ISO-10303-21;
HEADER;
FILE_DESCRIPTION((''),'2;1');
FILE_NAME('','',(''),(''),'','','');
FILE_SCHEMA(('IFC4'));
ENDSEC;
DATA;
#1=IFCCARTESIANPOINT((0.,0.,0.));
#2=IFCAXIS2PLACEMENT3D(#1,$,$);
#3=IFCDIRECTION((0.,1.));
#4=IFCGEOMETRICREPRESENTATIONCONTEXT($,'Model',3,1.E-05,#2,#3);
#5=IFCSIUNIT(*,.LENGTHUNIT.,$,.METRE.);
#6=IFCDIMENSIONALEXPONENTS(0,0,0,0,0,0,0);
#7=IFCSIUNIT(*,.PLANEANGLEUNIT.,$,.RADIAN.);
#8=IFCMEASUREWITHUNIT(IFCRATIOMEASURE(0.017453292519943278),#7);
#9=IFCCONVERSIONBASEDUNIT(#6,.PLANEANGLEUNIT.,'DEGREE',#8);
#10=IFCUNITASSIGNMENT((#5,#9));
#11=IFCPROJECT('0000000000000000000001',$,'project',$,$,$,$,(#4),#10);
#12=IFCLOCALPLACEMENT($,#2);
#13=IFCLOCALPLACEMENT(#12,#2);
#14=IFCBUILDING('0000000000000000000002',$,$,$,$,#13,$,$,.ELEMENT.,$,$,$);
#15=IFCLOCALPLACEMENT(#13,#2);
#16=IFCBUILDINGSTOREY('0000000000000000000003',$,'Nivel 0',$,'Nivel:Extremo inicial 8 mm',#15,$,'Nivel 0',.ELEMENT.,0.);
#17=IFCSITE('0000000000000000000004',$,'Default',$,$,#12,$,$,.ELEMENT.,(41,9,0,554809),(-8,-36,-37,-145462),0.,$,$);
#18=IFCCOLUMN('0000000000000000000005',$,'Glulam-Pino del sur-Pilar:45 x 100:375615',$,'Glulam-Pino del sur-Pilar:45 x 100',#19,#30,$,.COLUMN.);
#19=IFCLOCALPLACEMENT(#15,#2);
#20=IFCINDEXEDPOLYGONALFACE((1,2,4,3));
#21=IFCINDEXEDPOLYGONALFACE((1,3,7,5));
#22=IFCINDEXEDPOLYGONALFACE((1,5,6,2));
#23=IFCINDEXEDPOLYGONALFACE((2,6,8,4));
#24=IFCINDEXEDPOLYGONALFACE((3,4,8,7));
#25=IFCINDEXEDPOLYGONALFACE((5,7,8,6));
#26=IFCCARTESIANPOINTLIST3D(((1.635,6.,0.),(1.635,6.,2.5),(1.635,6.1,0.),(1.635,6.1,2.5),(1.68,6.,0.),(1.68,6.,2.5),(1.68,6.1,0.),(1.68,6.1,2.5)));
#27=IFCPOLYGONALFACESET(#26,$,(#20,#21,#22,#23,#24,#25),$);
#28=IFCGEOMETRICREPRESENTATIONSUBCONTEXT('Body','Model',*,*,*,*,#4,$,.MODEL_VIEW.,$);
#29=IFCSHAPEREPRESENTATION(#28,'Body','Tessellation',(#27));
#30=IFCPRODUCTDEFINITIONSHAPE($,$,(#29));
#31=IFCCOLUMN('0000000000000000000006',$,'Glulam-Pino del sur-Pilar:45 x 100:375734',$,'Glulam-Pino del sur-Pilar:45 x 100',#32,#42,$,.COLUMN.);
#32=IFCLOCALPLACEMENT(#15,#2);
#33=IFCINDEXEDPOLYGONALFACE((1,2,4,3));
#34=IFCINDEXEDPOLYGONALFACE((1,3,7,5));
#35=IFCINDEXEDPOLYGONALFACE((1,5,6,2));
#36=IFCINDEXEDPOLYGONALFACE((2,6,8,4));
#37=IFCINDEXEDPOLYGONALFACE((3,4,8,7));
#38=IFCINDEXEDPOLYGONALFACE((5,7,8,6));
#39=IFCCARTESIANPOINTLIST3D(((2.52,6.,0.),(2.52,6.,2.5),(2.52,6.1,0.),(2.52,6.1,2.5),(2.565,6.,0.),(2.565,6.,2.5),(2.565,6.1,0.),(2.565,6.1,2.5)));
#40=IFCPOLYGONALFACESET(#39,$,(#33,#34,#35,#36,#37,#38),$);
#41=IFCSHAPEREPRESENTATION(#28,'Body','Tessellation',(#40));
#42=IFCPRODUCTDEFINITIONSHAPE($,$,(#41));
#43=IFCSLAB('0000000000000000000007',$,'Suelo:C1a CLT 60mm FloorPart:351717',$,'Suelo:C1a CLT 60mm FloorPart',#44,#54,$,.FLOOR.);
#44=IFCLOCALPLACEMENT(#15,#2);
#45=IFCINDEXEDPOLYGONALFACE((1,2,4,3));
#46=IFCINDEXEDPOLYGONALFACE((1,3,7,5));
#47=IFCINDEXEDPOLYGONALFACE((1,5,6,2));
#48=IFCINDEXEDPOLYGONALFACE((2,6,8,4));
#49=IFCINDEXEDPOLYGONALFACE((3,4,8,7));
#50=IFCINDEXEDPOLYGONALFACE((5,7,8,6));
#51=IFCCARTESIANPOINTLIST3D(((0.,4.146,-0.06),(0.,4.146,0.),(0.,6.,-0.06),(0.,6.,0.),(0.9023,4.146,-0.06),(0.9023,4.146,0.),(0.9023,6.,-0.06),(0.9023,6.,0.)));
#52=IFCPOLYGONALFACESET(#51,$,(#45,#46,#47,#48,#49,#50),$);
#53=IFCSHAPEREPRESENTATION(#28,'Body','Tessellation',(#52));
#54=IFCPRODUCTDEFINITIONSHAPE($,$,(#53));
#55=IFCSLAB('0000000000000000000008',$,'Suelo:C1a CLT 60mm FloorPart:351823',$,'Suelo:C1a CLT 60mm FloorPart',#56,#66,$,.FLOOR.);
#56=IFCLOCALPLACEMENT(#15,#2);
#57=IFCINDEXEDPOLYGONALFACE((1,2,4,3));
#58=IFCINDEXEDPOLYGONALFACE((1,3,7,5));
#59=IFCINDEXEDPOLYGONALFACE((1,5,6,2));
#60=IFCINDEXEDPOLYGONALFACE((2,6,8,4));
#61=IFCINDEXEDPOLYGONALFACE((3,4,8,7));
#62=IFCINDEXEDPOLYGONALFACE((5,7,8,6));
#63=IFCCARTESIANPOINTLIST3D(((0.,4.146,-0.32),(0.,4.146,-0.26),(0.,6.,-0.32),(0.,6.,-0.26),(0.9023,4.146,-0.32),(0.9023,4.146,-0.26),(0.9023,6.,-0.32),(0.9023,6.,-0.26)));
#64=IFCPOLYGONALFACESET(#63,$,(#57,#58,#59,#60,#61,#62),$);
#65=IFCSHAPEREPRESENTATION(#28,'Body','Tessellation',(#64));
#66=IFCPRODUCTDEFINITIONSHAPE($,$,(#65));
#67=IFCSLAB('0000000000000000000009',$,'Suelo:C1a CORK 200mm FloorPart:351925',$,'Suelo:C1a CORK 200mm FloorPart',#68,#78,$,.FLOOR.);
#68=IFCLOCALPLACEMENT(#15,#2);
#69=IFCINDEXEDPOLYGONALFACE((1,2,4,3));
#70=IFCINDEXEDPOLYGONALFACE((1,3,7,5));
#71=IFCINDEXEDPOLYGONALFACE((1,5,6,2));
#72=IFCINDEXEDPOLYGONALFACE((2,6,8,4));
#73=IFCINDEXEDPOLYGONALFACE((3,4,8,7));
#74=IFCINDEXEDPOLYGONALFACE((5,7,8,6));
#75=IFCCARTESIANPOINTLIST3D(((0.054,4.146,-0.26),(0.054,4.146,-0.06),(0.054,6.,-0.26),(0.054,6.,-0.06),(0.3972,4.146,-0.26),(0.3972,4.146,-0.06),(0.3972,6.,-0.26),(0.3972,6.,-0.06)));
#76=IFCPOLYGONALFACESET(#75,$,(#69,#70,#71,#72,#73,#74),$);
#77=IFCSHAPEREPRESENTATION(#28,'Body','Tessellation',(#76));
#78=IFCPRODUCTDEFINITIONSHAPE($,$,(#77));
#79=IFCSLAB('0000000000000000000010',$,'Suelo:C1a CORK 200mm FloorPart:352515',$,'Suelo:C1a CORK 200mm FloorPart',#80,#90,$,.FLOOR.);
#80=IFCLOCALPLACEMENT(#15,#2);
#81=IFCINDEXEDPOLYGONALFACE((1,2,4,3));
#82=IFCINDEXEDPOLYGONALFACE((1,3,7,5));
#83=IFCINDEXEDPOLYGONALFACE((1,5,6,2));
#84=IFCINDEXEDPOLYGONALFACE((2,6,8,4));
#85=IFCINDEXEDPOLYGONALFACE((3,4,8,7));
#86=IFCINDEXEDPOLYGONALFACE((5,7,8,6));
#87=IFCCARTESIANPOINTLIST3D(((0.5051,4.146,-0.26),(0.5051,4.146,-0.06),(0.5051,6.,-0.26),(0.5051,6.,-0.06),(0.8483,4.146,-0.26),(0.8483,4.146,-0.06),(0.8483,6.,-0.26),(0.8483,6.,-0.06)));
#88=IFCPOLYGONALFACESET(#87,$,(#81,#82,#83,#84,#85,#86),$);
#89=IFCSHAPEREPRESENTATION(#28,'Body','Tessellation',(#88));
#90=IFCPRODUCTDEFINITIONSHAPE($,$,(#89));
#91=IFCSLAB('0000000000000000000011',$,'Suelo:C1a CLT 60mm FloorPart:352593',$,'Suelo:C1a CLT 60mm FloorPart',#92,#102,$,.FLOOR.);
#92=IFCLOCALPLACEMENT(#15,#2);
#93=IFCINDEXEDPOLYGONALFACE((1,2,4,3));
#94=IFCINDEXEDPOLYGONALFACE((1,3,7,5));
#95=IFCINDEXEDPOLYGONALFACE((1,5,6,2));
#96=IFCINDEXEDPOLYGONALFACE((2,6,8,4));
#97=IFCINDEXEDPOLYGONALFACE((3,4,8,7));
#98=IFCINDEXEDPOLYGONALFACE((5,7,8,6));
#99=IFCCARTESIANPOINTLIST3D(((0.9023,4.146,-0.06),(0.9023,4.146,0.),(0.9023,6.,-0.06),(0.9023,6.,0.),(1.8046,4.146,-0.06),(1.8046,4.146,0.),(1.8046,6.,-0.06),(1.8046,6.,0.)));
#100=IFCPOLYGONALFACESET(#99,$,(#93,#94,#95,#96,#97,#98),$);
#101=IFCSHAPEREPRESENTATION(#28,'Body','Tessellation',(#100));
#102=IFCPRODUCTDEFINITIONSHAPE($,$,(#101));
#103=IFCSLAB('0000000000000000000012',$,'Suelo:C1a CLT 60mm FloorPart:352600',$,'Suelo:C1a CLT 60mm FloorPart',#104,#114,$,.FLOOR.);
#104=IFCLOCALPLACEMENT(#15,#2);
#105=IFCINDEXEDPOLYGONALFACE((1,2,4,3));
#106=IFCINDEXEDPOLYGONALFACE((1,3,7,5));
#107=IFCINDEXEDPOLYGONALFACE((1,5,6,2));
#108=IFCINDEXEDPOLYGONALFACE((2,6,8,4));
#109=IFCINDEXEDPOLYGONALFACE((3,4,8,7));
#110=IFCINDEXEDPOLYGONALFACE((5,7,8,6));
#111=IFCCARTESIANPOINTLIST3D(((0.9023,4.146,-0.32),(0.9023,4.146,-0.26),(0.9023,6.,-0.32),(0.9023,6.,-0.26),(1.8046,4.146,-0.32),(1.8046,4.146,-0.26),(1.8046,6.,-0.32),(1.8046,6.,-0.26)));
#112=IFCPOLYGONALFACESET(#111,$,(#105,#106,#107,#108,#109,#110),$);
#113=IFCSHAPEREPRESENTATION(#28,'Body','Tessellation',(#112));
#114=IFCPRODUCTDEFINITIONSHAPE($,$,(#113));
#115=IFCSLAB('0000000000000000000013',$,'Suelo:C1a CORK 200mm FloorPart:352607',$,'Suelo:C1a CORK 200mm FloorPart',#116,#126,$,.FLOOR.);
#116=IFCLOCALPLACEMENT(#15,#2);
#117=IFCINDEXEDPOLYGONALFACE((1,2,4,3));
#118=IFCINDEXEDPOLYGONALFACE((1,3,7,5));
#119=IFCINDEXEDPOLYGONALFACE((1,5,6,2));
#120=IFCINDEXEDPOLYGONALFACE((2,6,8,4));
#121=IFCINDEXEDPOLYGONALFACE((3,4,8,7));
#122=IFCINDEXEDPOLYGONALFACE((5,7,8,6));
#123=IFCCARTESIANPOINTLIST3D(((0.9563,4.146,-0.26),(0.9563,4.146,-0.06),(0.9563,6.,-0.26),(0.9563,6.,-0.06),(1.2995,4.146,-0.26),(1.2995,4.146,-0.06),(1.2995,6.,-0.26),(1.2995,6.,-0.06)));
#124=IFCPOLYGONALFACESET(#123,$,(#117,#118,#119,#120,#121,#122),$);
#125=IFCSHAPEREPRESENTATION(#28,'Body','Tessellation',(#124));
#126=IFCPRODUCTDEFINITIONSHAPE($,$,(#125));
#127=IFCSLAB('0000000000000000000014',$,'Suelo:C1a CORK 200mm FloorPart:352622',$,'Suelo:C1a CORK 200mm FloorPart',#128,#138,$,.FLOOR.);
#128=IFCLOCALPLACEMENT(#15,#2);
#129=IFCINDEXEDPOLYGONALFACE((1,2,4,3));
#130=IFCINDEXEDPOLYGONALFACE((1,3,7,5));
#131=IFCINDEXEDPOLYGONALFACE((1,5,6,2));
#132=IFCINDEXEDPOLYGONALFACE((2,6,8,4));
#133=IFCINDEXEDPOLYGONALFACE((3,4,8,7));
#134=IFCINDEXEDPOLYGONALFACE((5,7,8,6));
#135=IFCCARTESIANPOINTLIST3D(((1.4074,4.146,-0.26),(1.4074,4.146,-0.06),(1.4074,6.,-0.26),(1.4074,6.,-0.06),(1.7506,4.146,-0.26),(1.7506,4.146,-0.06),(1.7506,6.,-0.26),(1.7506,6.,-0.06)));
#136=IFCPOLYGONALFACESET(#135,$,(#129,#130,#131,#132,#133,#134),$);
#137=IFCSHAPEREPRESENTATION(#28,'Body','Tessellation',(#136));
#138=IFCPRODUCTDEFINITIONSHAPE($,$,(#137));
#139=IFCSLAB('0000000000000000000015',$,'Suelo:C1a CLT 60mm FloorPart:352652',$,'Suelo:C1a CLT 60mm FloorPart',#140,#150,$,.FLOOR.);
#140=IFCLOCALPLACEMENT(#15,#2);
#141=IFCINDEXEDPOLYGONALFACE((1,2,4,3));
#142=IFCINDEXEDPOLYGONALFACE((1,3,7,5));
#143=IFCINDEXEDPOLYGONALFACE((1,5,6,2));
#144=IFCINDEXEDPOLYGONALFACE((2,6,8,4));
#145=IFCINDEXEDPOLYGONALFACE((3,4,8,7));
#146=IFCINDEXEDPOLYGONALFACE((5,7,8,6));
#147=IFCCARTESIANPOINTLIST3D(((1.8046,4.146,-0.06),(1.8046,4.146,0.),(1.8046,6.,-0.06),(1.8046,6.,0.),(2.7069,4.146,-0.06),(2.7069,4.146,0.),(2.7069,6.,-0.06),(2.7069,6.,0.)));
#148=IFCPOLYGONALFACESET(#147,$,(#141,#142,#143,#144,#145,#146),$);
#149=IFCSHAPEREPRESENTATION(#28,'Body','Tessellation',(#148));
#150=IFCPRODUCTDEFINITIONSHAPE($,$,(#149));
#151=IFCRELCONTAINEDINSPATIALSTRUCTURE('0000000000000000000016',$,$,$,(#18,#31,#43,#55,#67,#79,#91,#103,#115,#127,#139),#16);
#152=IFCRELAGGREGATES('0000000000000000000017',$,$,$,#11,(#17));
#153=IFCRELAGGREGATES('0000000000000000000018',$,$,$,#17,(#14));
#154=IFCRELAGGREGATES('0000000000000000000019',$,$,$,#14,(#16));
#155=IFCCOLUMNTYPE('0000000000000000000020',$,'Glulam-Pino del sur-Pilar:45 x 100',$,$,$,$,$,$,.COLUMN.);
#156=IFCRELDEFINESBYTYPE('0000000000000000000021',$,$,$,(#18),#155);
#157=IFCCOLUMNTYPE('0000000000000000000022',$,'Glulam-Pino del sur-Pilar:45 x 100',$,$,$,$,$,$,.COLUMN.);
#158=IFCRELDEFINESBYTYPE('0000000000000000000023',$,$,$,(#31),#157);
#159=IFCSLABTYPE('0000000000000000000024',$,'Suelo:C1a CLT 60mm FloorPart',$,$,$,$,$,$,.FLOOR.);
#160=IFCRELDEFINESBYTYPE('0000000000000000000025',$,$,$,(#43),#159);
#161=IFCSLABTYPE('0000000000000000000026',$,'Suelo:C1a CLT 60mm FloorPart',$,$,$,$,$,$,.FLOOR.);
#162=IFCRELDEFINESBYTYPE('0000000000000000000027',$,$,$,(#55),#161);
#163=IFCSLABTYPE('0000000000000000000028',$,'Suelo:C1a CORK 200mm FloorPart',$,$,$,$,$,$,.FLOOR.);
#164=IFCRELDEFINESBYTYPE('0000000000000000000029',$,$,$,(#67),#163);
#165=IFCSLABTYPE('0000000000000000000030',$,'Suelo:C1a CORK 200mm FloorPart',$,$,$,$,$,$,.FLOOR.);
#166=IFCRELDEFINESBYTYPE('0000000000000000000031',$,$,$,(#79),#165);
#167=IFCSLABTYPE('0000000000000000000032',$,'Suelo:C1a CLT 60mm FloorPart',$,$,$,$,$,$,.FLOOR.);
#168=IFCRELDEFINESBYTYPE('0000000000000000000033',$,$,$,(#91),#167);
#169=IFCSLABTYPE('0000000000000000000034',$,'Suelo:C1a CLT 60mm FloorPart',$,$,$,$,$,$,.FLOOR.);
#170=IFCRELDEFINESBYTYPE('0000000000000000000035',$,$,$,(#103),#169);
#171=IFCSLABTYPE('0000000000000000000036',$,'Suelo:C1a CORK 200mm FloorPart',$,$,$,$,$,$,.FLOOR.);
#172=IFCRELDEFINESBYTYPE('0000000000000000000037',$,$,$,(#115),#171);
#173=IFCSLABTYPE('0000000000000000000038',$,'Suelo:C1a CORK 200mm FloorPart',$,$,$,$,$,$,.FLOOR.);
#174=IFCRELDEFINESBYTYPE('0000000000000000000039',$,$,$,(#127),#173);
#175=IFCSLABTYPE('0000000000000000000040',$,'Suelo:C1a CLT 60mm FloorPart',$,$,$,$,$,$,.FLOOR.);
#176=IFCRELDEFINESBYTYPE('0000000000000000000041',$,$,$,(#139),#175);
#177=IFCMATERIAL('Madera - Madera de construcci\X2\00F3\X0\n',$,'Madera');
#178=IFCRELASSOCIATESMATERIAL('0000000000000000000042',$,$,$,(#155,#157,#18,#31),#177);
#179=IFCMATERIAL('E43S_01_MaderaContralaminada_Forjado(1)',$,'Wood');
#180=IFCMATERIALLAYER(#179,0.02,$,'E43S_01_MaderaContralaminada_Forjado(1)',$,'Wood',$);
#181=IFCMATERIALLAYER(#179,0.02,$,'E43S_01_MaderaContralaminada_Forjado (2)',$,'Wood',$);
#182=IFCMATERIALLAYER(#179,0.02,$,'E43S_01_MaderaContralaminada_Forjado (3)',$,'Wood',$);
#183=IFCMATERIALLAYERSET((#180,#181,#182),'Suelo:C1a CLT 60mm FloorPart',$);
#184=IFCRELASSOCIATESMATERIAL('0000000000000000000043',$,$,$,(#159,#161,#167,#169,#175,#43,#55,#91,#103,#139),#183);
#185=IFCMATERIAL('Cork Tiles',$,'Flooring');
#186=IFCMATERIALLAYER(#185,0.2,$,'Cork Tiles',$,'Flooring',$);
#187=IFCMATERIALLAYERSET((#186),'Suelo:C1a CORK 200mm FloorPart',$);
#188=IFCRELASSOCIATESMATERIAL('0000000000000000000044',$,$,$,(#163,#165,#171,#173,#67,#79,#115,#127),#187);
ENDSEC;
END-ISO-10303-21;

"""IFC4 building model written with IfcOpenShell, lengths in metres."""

from ifc_helpers import new_model, entity, si_unit, converted_unit, direction, frame, frame_2d, origin, origin_2d_with_axis, place, context, subcontext, project, spatial, polyline, segment, composite_curve, rectangle, outline, extrude, source, transform, mapped, material, layer, layer_set, layer_usage, material_profile, profile_set, profile_usage, type_object, type_shapes, element, save


model = new_model("IFC4")

# Units and contexts
model_context = context("Model", 3, precision=1e-05, world=origin(), true_north=direction((0.0, 1.0)))
body_context = subcontext(model_context, "Body", "Model", "MODEL_VIEW")
ifc_project = project(units=[si_unit("LENGTHUNIT", "METRE"), converted_unit("PLANEANGLEUNIT", "DEGREE", entity("IfcRatioMeasure", 0.017453292519943278), si_unit("PLANEANGLEUNIT", "RADIAN"), dimensions=[0, 0, 0, 0, 0, 0, 0])], contexts=[model_context])

# Site, building, storey
site_placement = place(None, origin())
site = spatial("IfcSite", under=ifc_project, at=site_placement, Name="Default", CompositionType="ELEMENT", RefLatitude=(41, 9, 0, 554809), RefLongitude=(-8, -36, -37, -145462), RefElevation=0.0)
building_placement = place(site_placement, origin())
building = spatial("IfcBuilding", under=site, at=building_placement, CompositionType="ELEMENT")
storey_placement = place(building_placement, origin())
storey = spatial("IfcBuildingStorey", under=building, at=storey_placement, Name="Nivel 0", ObjectType="Nivel:Extremo inicial 8 mm", LongName="Nivel 0", CompositionType="ELEMENT", Elevation=0.0)

# Columns
ifc_material_1 = material(Name="Madera - Madera de construcción", Category="Madera")
ifc_material_profile_1 = material_profile(ifc_material_1, outline(composite_curve([segment(polyline([(0.0225, 0.05, 0.0), (0.0225, -0.05, 0.0)]), True, "CONTINUOUS"), segment(polyline([(0.0225, -0.05, 0.0), (-0.0225, -0.05, 0.0)]), True, "CONTINUOUS"), segment(polyline([(-0.0225, -0.05, 0.0), (-0.0225, 0.05, 0.0)]), True, "CONTINUOUS"), segment(polyline([(-0.0225, 0.05, 0.0), (0.0225, 0.05, 0.0)]), True, "CONTINUOUS")], self_intersect=False), kind="CURVE"), Name="45 x 100")
ifc_material_profile_2 = material_profile(ifc_material_1, outline(composite_curve([segment(polyline([(0.0225, 0.05, 2.5), (-0.0225, 0.05, 2.5)]), True, "CONTINUOUS"), segment(polyline([(-0.0225, 0.05, 2.5), (-0.0225, -0.05, 2.5)]), True, "CONTINUOUS"), segment(polyline([(-0.0225, -0.05, 2.5), (0.0225, -0.05, 2.5)]), True, "CONTINUOUS"), segment(polyline([(0.0225, -0.05, 2.5), (0.0225, 0.05, 2.5)]), True, "CONTINUOUS")], self_intersect=False), kind="CURVE"), Name="45 x 100")
ifc_profile_set = profile_set([ifc_material_profile_1, ifc_material_profile_2], Name="45 x 100")
ifc_profile_usage_1 = profile_usage(ifc_profile_set)
column_type_1 = type_object("IfcColumnType", Name="Glulam-Pino del sur-Pilar:45 x 100", PredefinedType="COLUMN", material=ifc_profile_set)
shared_shape_1 = source(origin(), body_context, "Body", "SweptSolid", [
    extrude(rectangle(XDim=0.1, YDim=0.045, at=origin_2d_with_axis()), frame((0.0, 0.0, 0.0), z_axis=(0.0, 0.0, 1.0), x_axis=(0.0, -1.0, 0.0)), (0.0, 0.0, 1.0), 2.5),
])
type_shapes(column_type_1, [shared_shape_1])
column_1_placement = place(storey_placement, frame((1.6575, 6.05, 0.0)))
element("IfcColumn", 1, at=column_1_placement, inside=storey, type_object=column_type_1, material=ifc_profile_usage_1, Name="Glulam-Pino del sur-Pilar:45 x 100:375615", ObjectType="Glulam-Pino del sur-Pilar:45 x 100", PredefinedType="COLUMN", context=body_context, shape_type="MappedRepresentation", body=[
    mapped(shared_shape_1, transform((0.0, 0.0, 0.0), scale=1.0)),
])
ifc_profile_usage_2 = profile_usage(ifc_profile_set)
column_type_2 = type_object("IfcColumnType", Name="Glulam-Pino del sur-Pilar:45 x 100", PredefinedType="COLUMN", material=ifc_profile_set)
shared_shape_2 = source(origin(), body_context, "Body", "SweptSolid", [
    extrude(rectangle(XDim=0.1, YDim=0.045, at=origin_2d_with_axis()), frame((0.0, 0.0, 0.0), z_axis=(0.0, 0.0, 1.0), x_axis=(0.0, -1.0, 0.0)), (0.0, 0.0, 1.0), 2.5),
])
type_shapes(column_type_2, [shared_shape_2])
column_2_placement = place(storey_placement, frame((2.5425, 6.05, 0.0), z_axis=(0.0, 0.0, 1.0), x_axis=(-1.0, 0.0, 0.0)))
element("IfcColumn", 2, at=column_2_placement, inside=storey, type_object=column_type_2, material=ifc_profile_usage_2, Name="Glulam-Pino del sur-Pilar:45 x 100:375734", ObjectType="Glulam-Pino del sur-Pilar:45 x 100", PredefinedType="COLUMN", context=body_context, shape_type="MappedRepresentation", body=[
    mapped(shared_shape_2, transform((0.0, 0.0, 0.0), scale=1.0)),
])

# Slabs
ifc_material_2 = material(Name="E43S_01_MaderaContralaminada_Forjado(1)", Category="Wood")
ifc_layer_1 = layer(ifc_material_2, 0.02, Name="E43S_01_MaderaContralaminada_Forjado(1)", Category="Wood")
ifc_layer_2 = layer(ifc_material_2, 0.02, Name="E43S_01_MaderaContralaminada_Forjado (2)", Category="Wood")
ifc_layer_3 = layer(ifc_material_2, 0.02, Name="E43S_01_MaderaContralaminada_Forjado (3)", Category="Wood")
ifc_layer_set_1 = layer_set([ifc_layer_1, ifc_layer_2, ifc_layer_3], Name="Suelo:C1a CLT 60mm FloorPart")
ifc_layer_usage_1 = layer_usage(ifc_layer_set_1, "AXIS3", "POSITIVE", 0.0)
slab_type_1 = type_object("IfcSlabType", Name="Suelo:C1a CLT 60mm FloorPart", PredefinedType="FLOOR", material=ifc_layer_set_1)
slab_1_placement = place(storey_placement, origin())
element("IfcSlab", 3, at=slab_1_placement, inside=storey, type_object=slab_type_1, material=ifc_layer_usage_1, Name="Suelo:C1a CLT 60mm FloorPart:351717", ObjectType="Suelo:C1a CLT 60mm FloorPart", PredefinedType="FLOOR", context=body_context, shape_type="SweptSolid", body=[
    extrude(rectangle(XDim=1.854, YDim=0.9023, at=frame_2d((0.0, 0.0), x_axis=(1.0, 0.0))), frame((0.4512, 5.073, 0.0), z_axis=(0.0, 0.0, -1.0), x_axis=(0.0, 1.0, 0.0)), (0.0, 0.0, 1.0), 0.06),
])
ifc_layer_usage_2 = layer_usage(ifc_layer_set_1, "AXIS3", "POSITIVE", 0.0)
slab_type_2 = type_object("IfcSlabType", Name="Suelo:C1a CLT 60mm FloorPart", PredefinedType="FLOOR", material=ifc_layer_set_1)
slab_2_placement = place(storey_placement, origin())
element("IfcSlab", 4, at=slab_2_placement, inside=storey, type_object=slab_type_2, material=ifc_layer_usage_2, Name="Suelo:C1a CLT 60mm FloorPart:351823", ObjectType="Suelo:C1a CLT 60mm FloorPart", PredefinedType="FLOOR", context=body_context, shape_type="SweptSolid", body=[
    extrude(rectangle(XDim=1.854, YDim=0.9023, at=frame_2d((0.0, 0.0), x_axis=(1.0, 0.0))), frame((0.4512, 5.073, -0.26), z_axis=(0.0, 0.0, -1.0), x_axis=(0.0, 1.0, 0.0)), (0.0, 0.0, 1.0), 0.06),
])
ifc_material_3 = material(Name="Cork Tiles", Category="Flooring")
ifc_layer_4 = layer(ifc_material_3, 0.2, Name="Cork Tiles", Category="Flooring")
ifc_layer_set_2 = layer_set([ifc_layer_4], Name="Suelo:C1a CORK 200mm FloorPart")
ifc_layer_usage_3 = layer_usage(ifc_layer_set_2, "AXIS3", "POSITIVE", 0.0)
slab_type_3 = type_object("IfcSlabType", Name="Suelo:C1a CORK 200mm FloorPart", PredefinedType="FLOOR", material=ifc_layer_set_2)
slab_3_placement = place(storey_placement, origin())
element("IfcSlab", 5, at=slab_3_placement, inside=storey, type_object=slab_type_3, material=ifc_layer_usage_3, Name="Suelo:C1a CORK 200mm FloorPart:351925", ObjectType="Suelo:C1a CORK 200mm FloorPart", PredefinedType="FLOOR", context=body_context, shape_type="SweptSolid", body=[
    extrude(rectangle(XDim=1.854, YDim=0.3432, at=frame_2d((0.0, 0.0), x_axis=(1.0, 0.0))), frame((0.2256, 5.073, -0.06), z_axis=(0.0, 0.0, -1.0), x_axis=(0.0, 1.0, 0.0)), (0.0, 0.0, 1.0), 0.2),
])
ifc_layer_usage_4 = layer_usage(ifc_layer_set_2, "AXIS3", "POSITIVE", 0.0)
slab_type_4 = type_object("IfcSlabType", Name="Suelo:C1a CORK 200mm FloorPart", PredefinedType="FLOOR", material=ifc_layer_set_2)
slab_4_placement = place(storey_placement, origin())
element("IfcSlab", 6, at=slab_4_placement, inside=storey, type_object=slab_type_4, material=ifc_layer_usage_4, Name="Suelo:C1a CORK 200mm FloorPart:352515", ObjectType="Suelo:C1a CORK 200mm FloorPart", PredefinedType="FLOOR", context=body_context, shape_type="SweptSolid", body=[
    extrude(rectangle(XDim=1.854, YDim=0.3432, at=frame_2d((0.0, 0.0), x_axis=(1.0, 0.0))), frame((0.6767, 5.073, -0.06), z_axis=(0.0, 0.0, -1.0), x_axis=(0.0, 1.0, 0.0)), (0.0, 0.0, 1.0), 0.2),
])
ifc_layer_usage_5 = layer_usage(ifc_layer_set_1, "AXIS3", "POSITIVE", 0.0)
slab_type_5 = type_object("IfcSlabType", Name="Suelo:C1a CLT 60mm FloorPart", PredefinedType="FLOOR", material=ifc_layer_set_1)
slab_5_placement = place(storey_placement, origin())
element("IfcSlab", 7, at=slab_5_placement, inside=storey, type_object=slab_type_5, material=ifc_layer_usage_5, Name="Suelo:C1a CLT 60mm FloorPart:352593", ObjectType="Suelo:C1a CLT 60mm FloorPart", PredefinedType="FLOOR", context=body_context, shape_type="SweptSolid", body=[
    extrude(rectangle(XDim=1.854, YDim=0.9023, at=frame_2d((0.0, 0.0), x_axis=(1.0, 0.0))), frame((1.3535, 5.073, 0.0), z_axis=(0.0, 0.0, -1.0), x_axis=(0.0, 1.0, 0.0)), (0.0, 0.0, 1.0), 0.06),
])
ifc_layer_usage_6 = layer_usage(ifc_layer_set_1, "AXIS3", "POSITIVE", 0.0)
slab_type_6 = type_object("IfcSlabType", Name="Suelo:C1a CLT 60mm FloorPart", PredefinedType="FLOOR", material=ifc_layer_set_1)
slab_6_placement = place(storey_placement, origin())
element("IfcSlab", 8, at=slab_6_placement, inside=storey, type_object=slab_type_6, material=ifc_layer_usage_6, Name="Suelo:C1a CLT 60mm FloorPart:352600", ObjectType="Suelo:C1a CLT 60mm FloorPart", PredefinedType="FLOOR", context=body_context, shape_type="SweptSolid", body=[
    extrude(rectangle(XDim=1.854, YDim=0.9023, at=frame_2d((0.0, 0.0), x_axis=(1.0, 0.0))), frame((1.3535, 5.073, -0.26), z_axis=(0.0, 0.0, -1.0), x_axis=(0.0, 1.0, 0.0)), (0.0, 0.0, 1.0), 0.06),
])
ifc_layer_usage_7 = layer_usage(ifc_layer_set_2, "AXIS3", "POSITIVE", 0.0)
slab_type_7 = type_object("IfcSlabType", Name="Suelo:C1a CORK 200mm FloorPart", PredefinedType="FLOOR", material=ifc_layer_set_2)
slab_7_placement = place(storey_placement, origin())
element("IfcSlab", 9, at=slab_7_placement, inside=storey, type_object=slab_type_7, material=ifc_layer_usage_7, Name="Suelo:C1a CORK 200mm FloorPart:352607", ObjectType="Suelo:C1a CORK 200mm FloorPart", PredefinedType="FLOOR", context=body_context, shape_type="SweptSolid", body=[
    extrude(rectangle(XDim=1.854, YDim=0.3432, at=frame_2d((0.0, 0.0), x_axis=(1.0, 0.0))), frame((1.1279, 5.073, -0.06), z_axis=(0.0, 0.0, -1.0), x_axis=(0.0, 1.0, 0.0)), (0.0, 0.0, 1.0), 0.2),
])
ifc_layer_usage_8 = layer_usage(ifc_layer_set_2, "AXIS3", "POSITIVE", 0.0)
slab_type_8 = type_object("IfcSlabType", Name="Suelo:C1a CORK 200mm FloorPart", PredefinedType="FLOOR", material=ifc_layer_set_2)
slab_8_placement = place(storey_placement, origin())
element("IfcSlab", 10, at=slab_8_placement, inside=storey, type_object=slab_type_8, material=ifc_layer_usage_8, Name="Suelo:C1a CORK 200mm FloorPart:352622", ObjectType="Suelo:C1a CORK 200mm FloorPart", PredefinedType="FLOOR", context=body_context, shape_type="SweptSolid", body=[
    extrude(rectangle(XDim=1.854, YDim=0.3432, at=frame_2d((0.0, 0.0), x_axis=(1.0, 0.0))), frame((1.579, 5.073, -0.06), z_axis=(0.0, 0.0, -1.0), x_axis=(0.0, 1.0, 0.0)), (0.0, 0.0, 1.0), 0.2),
])
ifc_layer_usage_9 = layer_usage(ifc_layer_set_1, "AXIS3", "POSITIVE", 0.0)
slab_type_9 = type_object("IfcSlabType", Name="Suelo:C1a CLT 60mm FloorPart", PredefinedType="FLOOR", material=ifc_layer_set_1)
slab_9_placement = place(storey_placement, origin())
element("IfcSlab", 11, at=slab_9_placement, inside=storey, type_object=slab_type_9, material=ifc_layer_usage_9, Name="Suelo:C1a CLT 60mm FloorPart:352652", ObjectType="Suelo:C1a CLT 60mm FloorPart", PredefinedType="FLOOR", context=body_context, shape_type="SweptSolid", body=[
    extrude(rectangle(XDim=1.854, YDim=0.9023, at=frame_2d((0.0, 0.0), x_axis=(1.0, 0.0))), frame((2.2558, 5.073, 0.0), z_axis=(0.0, 0.0, -1.0), x_axis=(0.0, 1.0, 0.0)), (0.0, 0.0, 1.0), 0.06),
])

save(model, "model.ifc")
